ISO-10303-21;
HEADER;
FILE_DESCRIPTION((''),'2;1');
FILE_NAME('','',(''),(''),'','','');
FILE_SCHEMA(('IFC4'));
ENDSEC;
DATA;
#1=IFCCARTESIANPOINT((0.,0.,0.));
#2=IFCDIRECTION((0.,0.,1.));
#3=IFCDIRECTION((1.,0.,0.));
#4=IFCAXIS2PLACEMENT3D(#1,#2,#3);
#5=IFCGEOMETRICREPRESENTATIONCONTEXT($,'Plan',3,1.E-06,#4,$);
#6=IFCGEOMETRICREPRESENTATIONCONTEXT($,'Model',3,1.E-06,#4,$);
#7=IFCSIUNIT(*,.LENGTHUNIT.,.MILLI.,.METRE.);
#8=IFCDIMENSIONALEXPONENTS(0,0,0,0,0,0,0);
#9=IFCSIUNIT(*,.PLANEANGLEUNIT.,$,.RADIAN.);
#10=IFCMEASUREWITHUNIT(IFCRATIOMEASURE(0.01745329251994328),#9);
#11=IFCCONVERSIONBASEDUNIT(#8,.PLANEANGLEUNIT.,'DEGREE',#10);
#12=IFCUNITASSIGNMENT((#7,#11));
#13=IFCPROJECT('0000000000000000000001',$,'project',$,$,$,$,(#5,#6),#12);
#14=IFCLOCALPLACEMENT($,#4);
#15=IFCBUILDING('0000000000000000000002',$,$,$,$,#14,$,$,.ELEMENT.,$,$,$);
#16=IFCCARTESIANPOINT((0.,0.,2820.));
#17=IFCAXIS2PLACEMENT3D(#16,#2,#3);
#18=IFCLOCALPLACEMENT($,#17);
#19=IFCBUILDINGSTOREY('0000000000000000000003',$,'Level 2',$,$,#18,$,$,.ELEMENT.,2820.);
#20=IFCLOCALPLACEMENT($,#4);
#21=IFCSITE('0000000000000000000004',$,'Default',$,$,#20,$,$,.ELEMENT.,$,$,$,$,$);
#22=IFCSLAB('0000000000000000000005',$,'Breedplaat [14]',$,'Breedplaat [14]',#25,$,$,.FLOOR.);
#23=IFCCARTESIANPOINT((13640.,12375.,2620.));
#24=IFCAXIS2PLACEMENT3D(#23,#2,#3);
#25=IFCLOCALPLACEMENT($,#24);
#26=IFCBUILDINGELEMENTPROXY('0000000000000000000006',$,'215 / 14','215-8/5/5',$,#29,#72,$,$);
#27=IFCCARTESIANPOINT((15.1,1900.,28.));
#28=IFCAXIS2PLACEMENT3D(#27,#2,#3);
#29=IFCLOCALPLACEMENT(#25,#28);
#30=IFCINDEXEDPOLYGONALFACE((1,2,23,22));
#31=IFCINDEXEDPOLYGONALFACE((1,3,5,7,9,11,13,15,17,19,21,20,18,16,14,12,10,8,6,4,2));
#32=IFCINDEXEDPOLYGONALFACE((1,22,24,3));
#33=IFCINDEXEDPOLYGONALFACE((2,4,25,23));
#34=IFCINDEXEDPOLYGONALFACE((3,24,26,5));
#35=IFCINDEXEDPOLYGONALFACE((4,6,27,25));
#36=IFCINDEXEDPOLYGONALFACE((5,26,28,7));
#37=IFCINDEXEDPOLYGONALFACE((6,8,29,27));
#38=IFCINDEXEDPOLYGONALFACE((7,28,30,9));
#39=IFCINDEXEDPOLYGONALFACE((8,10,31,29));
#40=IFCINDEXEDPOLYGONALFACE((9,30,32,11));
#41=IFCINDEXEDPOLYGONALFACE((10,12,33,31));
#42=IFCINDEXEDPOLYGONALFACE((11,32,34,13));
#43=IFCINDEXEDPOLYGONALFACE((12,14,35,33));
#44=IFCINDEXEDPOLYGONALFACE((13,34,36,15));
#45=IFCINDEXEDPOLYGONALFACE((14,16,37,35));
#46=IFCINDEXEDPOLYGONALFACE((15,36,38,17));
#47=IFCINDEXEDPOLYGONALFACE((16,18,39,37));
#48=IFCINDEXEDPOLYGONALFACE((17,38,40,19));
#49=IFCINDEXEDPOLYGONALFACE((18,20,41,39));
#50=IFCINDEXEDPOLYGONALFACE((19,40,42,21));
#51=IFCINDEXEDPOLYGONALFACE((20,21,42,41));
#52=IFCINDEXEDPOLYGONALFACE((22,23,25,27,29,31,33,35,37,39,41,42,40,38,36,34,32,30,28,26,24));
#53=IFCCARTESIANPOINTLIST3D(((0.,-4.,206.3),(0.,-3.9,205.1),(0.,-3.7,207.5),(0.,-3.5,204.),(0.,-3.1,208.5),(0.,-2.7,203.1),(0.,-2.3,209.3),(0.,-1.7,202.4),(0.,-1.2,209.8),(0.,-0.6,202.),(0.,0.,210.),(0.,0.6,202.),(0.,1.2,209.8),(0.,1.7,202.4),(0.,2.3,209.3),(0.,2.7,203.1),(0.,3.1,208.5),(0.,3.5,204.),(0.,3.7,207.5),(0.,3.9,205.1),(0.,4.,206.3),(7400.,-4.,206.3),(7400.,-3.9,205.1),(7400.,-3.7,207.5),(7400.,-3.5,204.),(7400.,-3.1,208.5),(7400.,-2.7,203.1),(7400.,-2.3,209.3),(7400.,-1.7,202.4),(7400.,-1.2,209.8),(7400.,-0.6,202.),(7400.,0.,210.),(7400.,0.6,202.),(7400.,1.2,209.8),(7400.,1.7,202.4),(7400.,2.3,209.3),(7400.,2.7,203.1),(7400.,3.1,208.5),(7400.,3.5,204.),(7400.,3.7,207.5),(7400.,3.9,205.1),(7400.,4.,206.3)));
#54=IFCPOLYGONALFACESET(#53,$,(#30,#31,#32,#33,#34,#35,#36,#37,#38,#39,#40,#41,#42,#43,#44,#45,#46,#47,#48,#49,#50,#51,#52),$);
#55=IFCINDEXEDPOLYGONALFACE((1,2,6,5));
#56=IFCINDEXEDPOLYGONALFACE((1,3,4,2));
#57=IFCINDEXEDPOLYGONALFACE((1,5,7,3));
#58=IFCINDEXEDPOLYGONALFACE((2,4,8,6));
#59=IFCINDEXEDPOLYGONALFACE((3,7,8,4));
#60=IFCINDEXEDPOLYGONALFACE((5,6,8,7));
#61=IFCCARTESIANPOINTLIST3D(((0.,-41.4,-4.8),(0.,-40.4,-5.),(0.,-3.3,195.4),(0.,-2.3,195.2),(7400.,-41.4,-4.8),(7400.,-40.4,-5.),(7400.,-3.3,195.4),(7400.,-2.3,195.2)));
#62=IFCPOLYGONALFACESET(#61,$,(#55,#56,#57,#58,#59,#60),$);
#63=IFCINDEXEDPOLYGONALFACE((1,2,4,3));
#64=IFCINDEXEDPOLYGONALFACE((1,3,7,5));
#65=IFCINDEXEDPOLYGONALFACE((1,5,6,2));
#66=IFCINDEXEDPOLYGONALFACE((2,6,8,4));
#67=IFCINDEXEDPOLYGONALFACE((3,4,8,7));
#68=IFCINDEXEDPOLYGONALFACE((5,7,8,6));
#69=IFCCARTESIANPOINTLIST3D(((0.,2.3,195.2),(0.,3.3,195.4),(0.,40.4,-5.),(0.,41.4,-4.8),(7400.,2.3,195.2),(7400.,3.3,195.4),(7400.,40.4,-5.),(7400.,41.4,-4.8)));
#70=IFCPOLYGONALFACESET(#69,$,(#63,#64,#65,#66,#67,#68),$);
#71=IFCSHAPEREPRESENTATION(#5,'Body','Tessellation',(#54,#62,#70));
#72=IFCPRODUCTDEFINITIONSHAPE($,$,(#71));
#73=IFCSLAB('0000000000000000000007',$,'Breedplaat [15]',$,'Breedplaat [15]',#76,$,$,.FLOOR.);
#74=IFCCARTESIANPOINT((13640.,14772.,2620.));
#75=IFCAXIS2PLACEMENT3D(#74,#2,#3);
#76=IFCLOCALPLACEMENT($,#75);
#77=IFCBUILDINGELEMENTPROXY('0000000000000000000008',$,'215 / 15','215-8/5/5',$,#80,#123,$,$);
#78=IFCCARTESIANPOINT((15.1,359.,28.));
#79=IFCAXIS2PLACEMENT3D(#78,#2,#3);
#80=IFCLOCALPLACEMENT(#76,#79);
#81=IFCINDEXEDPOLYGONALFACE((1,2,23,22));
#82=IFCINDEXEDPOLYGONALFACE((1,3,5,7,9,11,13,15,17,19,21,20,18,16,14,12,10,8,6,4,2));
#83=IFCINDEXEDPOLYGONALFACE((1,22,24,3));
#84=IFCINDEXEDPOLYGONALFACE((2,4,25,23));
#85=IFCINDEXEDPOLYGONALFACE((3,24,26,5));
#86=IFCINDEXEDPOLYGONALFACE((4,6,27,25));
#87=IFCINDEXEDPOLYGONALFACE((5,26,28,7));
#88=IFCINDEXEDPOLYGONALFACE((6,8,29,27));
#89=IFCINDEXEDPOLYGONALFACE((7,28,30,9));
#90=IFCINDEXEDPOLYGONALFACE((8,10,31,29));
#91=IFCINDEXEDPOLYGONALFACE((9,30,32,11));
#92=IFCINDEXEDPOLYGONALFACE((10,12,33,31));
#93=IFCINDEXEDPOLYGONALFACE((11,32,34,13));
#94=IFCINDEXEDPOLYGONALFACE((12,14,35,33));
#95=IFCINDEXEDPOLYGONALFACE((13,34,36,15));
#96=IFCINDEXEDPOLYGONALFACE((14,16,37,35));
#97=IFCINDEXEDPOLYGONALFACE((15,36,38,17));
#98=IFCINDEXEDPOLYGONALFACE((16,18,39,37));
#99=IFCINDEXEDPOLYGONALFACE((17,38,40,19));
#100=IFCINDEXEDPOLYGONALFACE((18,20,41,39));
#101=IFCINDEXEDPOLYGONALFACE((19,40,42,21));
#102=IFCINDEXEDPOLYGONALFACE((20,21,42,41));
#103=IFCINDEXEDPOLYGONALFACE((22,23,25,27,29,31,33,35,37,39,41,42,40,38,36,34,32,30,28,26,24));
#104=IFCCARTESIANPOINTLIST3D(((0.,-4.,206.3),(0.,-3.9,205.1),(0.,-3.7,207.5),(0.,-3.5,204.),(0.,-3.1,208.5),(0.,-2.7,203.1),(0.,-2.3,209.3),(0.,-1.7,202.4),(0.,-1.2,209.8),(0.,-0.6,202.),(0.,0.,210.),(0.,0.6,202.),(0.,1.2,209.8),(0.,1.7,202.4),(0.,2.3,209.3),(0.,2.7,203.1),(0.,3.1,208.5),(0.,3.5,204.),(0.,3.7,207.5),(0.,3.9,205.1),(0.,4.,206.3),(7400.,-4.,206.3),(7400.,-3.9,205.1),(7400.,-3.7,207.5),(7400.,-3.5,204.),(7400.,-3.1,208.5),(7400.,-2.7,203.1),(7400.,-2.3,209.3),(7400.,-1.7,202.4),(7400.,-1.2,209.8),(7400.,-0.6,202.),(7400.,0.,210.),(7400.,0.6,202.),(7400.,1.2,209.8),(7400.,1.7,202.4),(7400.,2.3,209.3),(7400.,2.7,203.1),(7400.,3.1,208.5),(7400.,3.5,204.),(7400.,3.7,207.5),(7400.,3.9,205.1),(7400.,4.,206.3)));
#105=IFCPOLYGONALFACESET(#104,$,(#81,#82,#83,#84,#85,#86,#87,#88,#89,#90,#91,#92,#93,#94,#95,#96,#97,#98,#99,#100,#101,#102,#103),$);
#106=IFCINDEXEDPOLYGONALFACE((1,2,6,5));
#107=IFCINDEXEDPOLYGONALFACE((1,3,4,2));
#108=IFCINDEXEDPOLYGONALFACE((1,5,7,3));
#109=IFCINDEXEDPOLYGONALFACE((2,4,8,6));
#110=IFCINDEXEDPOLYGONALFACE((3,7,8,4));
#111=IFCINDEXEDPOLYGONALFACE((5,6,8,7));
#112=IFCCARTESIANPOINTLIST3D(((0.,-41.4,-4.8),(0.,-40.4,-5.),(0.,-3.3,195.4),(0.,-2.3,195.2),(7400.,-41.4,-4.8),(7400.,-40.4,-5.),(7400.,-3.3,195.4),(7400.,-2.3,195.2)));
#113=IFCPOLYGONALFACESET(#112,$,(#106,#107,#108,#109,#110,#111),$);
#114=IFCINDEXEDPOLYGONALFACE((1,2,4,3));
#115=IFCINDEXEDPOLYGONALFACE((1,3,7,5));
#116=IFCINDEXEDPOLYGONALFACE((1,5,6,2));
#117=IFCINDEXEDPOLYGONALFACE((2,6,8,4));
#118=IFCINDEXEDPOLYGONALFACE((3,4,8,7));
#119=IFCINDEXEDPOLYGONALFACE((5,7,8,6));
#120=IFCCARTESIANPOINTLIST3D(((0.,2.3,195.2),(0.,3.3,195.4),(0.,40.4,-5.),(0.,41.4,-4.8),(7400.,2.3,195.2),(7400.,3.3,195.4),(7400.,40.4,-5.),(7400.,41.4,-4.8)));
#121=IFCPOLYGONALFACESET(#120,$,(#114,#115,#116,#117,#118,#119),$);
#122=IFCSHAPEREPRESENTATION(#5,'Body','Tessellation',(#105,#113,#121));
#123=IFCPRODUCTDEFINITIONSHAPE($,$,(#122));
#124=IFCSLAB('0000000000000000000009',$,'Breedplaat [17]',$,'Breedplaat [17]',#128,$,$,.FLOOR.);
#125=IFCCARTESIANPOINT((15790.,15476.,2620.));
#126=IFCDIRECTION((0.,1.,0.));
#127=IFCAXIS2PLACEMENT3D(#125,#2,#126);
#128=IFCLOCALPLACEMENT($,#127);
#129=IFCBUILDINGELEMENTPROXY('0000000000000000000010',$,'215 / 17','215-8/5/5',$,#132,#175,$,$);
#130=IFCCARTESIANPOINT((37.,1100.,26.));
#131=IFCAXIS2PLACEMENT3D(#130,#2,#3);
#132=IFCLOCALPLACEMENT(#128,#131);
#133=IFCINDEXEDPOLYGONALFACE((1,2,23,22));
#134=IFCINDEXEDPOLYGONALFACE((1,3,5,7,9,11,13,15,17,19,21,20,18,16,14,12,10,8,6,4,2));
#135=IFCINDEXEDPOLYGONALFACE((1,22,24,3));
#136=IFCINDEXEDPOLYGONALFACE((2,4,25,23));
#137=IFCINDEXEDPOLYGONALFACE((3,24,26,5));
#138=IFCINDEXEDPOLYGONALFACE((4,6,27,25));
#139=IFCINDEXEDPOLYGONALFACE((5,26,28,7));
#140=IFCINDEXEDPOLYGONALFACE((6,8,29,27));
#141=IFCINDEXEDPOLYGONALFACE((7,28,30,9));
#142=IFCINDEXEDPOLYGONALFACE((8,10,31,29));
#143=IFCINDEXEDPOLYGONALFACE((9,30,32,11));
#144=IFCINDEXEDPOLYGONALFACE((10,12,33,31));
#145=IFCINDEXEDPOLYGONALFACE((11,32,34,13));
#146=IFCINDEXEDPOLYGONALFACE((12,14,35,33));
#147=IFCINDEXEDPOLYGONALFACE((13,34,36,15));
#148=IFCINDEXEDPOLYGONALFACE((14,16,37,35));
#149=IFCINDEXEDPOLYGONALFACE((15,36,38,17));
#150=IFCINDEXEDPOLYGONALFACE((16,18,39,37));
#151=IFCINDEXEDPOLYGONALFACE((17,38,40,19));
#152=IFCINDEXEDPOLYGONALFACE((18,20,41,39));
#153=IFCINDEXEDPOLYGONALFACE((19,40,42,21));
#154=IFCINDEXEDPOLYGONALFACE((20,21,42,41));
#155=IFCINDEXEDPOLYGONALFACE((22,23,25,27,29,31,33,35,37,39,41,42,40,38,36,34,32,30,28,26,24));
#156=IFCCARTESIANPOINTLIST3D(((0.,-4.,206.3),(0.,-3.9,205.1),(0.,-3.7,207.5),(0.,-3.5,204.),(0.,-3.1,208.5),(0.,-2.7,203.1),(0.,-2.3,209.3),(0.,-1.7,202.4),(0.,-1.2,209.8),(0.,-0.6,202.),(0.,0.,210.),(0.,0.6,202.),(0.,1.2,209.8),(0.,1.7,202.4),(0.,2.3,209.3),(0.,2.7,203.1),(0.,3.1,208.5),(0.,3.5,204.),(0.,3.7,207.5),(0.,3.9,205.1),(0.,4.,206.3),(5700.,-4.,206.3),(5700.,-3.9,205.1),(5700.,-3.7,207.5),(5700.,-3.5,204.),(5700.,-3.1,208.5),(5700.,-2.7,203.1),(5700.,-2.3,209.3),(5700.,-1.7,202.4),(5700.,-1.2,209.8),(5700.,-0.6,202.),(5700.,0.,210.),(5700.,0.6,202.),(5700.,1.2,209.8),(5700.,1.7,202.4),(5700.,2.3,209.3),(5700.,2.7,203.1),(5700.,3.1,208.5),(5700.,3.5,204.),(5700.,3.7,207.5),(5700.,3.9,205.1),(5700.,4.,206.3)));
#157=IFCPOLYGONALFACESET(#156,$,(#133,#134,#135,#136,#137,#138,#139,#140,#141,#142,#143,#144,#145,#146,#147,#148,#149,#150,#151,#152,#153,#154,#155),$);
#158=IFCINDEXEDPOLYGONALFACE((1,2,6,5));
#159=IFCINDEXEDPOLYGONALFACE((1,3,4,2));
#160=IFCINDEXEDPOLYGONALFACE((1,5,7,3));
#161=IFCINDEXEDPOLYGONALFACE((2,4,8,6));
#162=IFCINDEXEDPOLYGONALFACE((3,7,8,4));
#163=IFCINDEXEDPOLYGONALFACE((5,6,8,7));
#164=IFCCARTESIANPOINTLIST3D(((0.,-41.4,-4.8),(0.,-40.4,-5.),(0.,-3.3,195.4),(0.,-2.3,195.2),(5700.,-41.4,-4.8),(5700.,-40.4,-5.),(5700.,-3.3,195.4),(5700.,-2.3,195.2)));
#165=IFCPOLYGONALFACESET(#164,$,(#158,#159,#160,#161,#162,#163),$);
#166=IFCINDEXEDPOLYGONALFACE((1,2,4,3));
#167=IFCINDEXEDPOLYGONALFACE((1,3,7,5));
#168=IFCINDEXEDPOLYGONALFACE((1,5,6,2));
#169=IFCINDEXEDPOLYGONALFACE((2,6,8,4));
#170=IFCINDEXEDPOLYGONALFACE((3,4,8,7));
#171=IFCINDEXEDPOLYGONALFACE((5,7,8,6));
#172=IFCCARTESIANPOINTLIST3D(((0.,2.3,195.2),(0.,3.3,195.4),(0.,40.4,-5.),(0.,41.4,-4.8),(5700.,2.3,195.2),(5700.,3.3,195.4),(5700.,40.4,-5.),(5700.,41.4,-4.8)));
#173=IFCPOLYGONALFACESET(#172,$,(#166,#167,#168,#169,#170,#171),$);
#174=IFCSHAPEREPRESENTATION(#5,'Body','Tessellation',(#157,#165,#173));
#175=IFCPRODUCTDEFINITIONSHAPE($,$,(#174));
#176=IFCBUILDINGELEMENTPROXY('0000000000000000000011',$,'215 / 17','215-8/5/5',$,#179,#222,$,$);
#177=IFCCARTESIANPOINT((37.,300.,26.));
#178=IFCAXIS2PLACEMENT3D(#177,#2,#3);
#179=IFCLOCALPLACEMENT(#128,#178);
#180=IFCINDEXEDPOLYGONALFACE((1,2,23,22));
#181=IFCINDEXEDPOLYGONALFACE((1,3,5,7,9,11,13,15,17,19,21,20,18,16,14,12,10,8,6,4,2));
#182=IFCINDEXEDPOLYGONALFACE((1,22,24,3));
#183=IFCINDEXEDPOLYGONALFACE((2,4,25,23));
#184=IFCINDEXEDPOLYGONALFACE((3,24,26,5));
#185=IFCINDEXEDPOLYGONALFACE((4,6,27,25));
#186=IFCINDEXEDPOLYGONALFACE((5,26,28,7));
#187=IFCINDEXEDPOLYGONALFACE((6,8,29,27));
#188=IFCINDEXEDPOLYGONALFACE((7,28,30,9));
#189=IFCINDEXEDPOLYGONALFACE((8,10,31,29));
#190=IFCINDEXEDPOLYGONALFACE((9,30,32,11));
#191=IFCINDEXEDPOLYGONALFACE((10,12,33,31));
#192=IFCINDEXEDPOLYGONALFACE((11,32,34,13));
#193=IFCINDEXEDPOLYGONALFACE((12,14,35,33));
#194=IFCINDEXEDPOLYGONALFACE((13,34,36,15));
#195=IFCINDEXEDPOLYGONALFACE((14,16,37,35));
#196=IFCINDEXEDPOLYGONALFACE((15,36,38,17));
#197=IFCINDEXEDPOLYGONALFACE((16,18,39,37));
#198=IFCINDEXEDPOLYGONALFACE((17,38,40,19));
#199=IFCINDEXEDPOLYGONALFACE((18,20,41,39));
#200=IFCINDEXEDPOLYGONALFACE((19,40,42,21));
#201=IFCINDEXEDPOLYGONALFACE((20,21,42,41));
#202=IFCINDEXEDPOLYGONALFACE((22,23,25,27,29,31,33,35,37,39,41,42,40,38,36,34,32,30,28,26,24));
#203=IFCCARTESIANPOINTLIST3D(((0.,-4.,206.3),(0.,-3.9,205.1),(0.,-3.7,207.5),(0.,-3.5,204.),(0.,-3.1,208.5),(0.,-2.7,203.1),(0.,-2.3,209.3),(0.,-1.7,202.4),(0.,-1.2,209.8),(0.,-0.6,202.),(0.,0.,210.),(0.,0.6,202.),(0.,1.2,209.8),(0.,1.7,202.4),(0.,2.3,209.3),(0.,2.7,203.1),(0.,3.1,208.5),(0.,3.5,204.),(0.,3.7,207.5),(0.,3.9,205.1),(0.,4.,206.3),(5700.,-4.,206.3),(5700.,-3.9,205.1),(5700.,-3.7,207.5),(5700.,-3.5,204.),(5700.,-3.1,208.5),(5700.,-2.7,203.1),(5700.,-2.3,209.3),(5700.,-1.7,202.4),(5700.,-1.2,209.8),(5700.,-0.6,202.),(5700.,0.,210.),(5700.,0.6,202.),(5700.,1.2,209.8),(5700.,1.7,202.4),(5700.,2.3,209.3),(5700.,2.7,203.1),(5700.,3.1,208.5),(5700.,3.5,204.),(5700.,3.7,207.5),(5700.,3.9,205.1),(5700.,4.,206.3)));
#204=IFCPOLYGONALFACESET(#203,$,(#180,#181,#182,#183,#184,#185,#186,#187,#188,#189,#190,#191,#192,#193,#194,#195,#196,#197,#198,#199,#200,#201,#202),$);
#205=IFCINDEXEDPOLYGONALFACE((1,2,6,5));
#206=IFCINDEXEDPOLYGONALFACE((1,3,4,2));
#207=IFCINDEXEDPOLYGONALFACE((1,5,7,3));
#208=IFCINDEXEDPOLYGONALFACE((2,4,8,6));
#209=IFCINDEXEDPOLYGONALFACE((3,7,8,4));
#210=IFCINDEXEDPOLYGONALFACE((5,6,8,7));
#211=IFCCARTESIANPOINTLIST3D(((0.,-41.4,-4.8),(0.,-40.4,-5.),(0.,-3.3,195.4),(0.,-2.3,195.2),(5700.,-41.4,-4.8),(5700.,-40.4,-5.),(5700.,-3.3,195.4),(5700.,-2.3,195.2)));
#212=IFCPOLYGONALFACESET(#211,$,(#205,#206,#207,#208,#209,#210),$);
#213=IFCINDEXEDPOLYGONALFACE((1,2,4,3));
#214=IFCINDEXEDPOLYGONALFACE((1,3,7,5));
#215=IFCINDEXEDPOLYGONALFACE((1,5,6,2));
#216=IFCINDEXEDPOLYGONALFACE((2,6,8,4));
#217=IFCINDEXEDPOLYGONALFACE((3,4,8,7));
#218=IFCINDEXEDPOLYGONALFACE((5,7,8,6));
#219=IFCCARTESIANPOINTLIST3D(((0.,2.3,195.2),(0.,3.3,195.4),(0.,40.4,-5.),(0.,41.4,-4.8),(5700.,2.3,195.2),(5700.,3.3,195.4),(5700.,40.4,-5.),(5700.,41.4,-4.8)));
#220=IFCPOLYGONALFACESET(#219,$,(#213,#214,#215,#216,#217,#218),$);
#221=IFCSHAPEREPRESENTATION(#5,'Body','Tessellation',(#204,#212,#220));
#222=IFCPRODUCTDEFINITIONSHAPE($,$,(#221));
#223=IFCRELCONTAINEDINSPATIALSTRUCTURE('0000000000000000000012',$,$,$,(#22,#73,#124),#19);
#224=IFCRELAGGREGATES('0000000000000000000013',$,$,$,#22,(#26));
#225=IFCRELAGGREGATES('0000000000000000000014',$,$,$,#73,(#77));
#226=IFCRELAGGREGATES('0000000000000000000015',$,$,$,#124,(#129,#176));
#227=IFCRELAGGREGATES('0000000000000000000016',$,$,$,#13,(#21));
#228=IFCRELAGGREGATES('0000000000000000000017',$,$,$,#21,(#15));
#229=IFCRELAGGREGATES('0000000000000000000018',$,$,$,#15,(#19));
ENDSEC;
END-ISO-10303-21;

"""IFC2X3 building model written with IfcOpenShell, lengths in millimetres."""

from ifc_helpers import new_model, entity, si_unit, converted_unit, frame, origin_with_axes, origin_2d_with_axis, place, context, project, spatial, rectangle, circle, extrude, element, aggregate, save


model = new_model("IFC2X3")

# Units and contexts
plan_context = context("Plan", 3, precision=1e-06, world=origin_with_axes())
model_context = context("Model", 3, precision=1e-06, world=origin_with_axes())
ifc_project = project(units=[si_unit("LENGTHUNIT", "METRE", prefix="MILLI"), converted_unit("PLANEANGLEUNIT", "DEGREE", entity("IfcRatioMeasure", 0.01745329251994328), si_unit("PLANEANGLEUNIT", "RADIAN"), dimensions=[0, 0, 0, 0, 0, 0, 0])], contexts=[plan_context, model_context])

# Site, building, storey
site_placement = place(None, origin_with_axes())
site = spatial("IfcSite", under=ifc_project, at=site_placement, Name="Default", CompositionType="ELEMENT")
building_placement = place(None, origin_with_axes())
building = spatial("IfcBuilding", under=site, at=building_placement, CompositionType="ELEMENT")
storey_placement = place(None, frame((0.0, 0.0, 2820.0), z_axis=(0.0, 0.0, 1.0), x_axis=(1.0, 0.0, 0.0)))
storey = spatial("IfcBuildingStorey", under=building, at=storey_placement, Name="Level 2", CompositionType="ELEMENT", Elevation=2820.0)

# Slabs, building element proxies
slab_1_placement = place(None, frame((13640.0, 12375.0, 2620.0), z_axis=(0.0, 0.0, 1.0), x_axis=(1.0, 0.0, 0.0)))
slab_1 = element("IfcSlab", 1, at=slab_1_placement, inside=storey, Name="Breedplaat [14]", ObjectType="Breedplaat [14]", PredefinedType="FLOOR")
proxy_1_placement = place(slab_1_placement, frame((15.1, 1900.0, 28.0), z_axis=(0.0, 0.0, 1.0), x_axis=(1.0, 0.0, 0.0)))
proxy_1 = element("IfcBuildingElementProxy", 2, at=proxy_1_placement, Name="215 / 14", Description="215-8/5/5", context=plan_context, shape_type="SweptSolid", body=[
    extrude(circle(Radius=4.0, at=origin_2d_with_axis()), frame((0.0, 0.0, 206.0), z_axis=(1.0, 0.0, 0.0), x_axis=(0.0, 0.0, 1.0)), (0.0, 0.0, 1.0), 7400.0),
    extrude(rectangle(XDim=203.8, YDim=1.0, at=origin_2d_with_axis()), frame((0.0, -21.9, 95.2), z_axis=(1.0, 0.0, 0.0), x_axis=(0.0, 0.187112, 0.982339)), (0.0, 0.0, 1.0), 7400.0),
    extrude(rectangle(XDim=203.8, YDim=1.0, at=origin_2d_with_axis()), frame((0.0, 21.9, 95.2), z_axis=(1.0, 0.0, 0.0), x_axis=(0.0, -0.187112, 0.982339)), (0.0, 0.0, 1.0), 7400.0),
])
aggregate(slab_1, [proxy_1])
slab_2_placement = place(None, frame((13640.0, 14772.0, 2620.0), z_axis=(0.0, 0.0, 1.0), x_axis=(1.0, 0.0, 0.0)))
slab_2 = element("IfcSlab", 3, at=slab_2_placement, inside=storey, Name="Breedplaat [15]", ObjectType="Breedplaat [15]", PredefinedType="FLOOR")
proxy_2_placement = place(slab_2_placement, frame((15.1, 359.0, 28.0), z_axis=(0.0, 0.0, 1.0), x_axis=(1.0, 0.0, 0.0)))
proxy_2 = element("IfcBuildingElementProxy", 4, at=proxy_2_placement, Name="215 / 15", Description="215-8/5/5", context=plan_context, shape_type="SweptSolid", body=[
    extrude(circle(Radius=4.0, at=origin_2d_with_axis()), frame((0.0, 0.0, 206.0), z_axis=(1.0, 0.0, 0.0), x_axis=(0.0, 0.0, 1.0)), (0.0, 0.0, 1.0), 7400.0),
    extrude(rectangle(XDim=203.8, YDim=1.0, at=origin_2d_with_axis()), frame((0.0, -21.9, 95.2), z_axis=(1.0, 0.0, 0.0), x_axis=(0.0, 0.187112, 0.982339)), (0.0, 0.0, 1.0), 7400.0),
    extrude(rectangle(XDim=203.8, YDim=1.0, at=origin_2d_with_axis()), frame((0.0, 21.9, 95.2), z_axis=(1.0, 0.0, 0.0), x_axis=(0.0, -0.187112, 0.982339)), (0.0, 0.0, 1.0), 7400.0),
])
aggregate(slab_2, [proxy_2])

# Slab, building element proxies
slab_3_placement = place(None, frame((15790.0, 15476.0, 2620.0), z_axis=(0.0, 0.0, 1.0), x_axis=(0.0, 1.0, 0.0)))
slab_3 = element("IfcSlab", 5, at=slab_3_placement, inside=storey, Name="Breedplaat [17]", ObjectType="Breedplaat [17]", PredefinedType="FLOOR")
proxy_3_placement = place(slab_3_placement, frame((37.0, 1100.0, 26.0), z_axis=(0.0, 0.0, 1.0), x_axis=(1.0, 0.0, 0.0)))
proxy_3 = element("IfcBuildingElementProxy", 6, at=proxy_3_placement, Name="215 / 17", Description="215-8/5/5", context=plan_context, shape_type="SweptSolid", body=[
    extrude(circle(Radius=4.0, at=origin_2d_with_axis()), frame((0.0, 0.0, 206.0), z_axis=(1.0, 0.0, 0.0), x_axis=(0.0, 0.0, 1.0)), (0.0, 0.0, 1.0), 5700.0),
    extrude(rectangle(XDim=203.8, YDim=1.0, at=origin_2d_with_axis()), frame((0.0, -21.9, 95.2), z_axis=(1.0, 0.0, 0.0), x_axis=(0.0, 0.187112, 0.982339)), (0.0, 0.0, 1.0), 5700.0),
    extrude(rectangle(XDim=203.8, YDim=1.0, at=origin_2d_with_axis()), frame((0.0, 21.9, 95.2), z_axis=(1.0, 0.0, 0.0), x_axis=(0.0, -0.187112, 0.982339)), (0.0, 0.0, 1.0), 5700.0),
])
proxy_4_placement = place(slab_3_placement, frame((37.0, 300.0, 26.0), z_axis=(0.0, 0.0, 1.0), x_axis=(1.0, 0.0, 0.0)))
proxy_4 = element("IfcBuildingElementProxy", 7, at=proxy_4_placement, Name="215 / 17", Description="215-8/5/5", context=plan_context, shape_type="SweptSolid", body=[
    extrude(circle(Radius=4.0, at=origin_2d_with_axis()), frame((0.0, 0.0, 206.0), z_axis=(1.0, 0.0, 0.0), x_axis=(0.0, 0.0, 1.0)), (0.0, 0.0, 1.0), 5700.0),
    extrude(rectangle(XDim=203.8, YDim=1.0, at=origin_2d_with_axis()), frame((0.0, -21.9, 95.2), z_axis=(1.0, 0.0, 0.0), x_axis=(0.0, 0.187112, 0.982339)), (0.0, 0.0, 1.0), 5700.0),
    extrude(rectangle(XDim=203.8, YDim=1.0, at=origin_2d_with_axis()), frame((0.0, 21.9, 95.2), z_axis=(1.0, 0.0, 0.0), x_axis=(0.0, -0.187112, 0.982339)), (0.0, 0.0, 1.0), 5700.0),
])
aggregate(slab_3, [proxy_3, proxy_4])

save(model, "model.ifc")
